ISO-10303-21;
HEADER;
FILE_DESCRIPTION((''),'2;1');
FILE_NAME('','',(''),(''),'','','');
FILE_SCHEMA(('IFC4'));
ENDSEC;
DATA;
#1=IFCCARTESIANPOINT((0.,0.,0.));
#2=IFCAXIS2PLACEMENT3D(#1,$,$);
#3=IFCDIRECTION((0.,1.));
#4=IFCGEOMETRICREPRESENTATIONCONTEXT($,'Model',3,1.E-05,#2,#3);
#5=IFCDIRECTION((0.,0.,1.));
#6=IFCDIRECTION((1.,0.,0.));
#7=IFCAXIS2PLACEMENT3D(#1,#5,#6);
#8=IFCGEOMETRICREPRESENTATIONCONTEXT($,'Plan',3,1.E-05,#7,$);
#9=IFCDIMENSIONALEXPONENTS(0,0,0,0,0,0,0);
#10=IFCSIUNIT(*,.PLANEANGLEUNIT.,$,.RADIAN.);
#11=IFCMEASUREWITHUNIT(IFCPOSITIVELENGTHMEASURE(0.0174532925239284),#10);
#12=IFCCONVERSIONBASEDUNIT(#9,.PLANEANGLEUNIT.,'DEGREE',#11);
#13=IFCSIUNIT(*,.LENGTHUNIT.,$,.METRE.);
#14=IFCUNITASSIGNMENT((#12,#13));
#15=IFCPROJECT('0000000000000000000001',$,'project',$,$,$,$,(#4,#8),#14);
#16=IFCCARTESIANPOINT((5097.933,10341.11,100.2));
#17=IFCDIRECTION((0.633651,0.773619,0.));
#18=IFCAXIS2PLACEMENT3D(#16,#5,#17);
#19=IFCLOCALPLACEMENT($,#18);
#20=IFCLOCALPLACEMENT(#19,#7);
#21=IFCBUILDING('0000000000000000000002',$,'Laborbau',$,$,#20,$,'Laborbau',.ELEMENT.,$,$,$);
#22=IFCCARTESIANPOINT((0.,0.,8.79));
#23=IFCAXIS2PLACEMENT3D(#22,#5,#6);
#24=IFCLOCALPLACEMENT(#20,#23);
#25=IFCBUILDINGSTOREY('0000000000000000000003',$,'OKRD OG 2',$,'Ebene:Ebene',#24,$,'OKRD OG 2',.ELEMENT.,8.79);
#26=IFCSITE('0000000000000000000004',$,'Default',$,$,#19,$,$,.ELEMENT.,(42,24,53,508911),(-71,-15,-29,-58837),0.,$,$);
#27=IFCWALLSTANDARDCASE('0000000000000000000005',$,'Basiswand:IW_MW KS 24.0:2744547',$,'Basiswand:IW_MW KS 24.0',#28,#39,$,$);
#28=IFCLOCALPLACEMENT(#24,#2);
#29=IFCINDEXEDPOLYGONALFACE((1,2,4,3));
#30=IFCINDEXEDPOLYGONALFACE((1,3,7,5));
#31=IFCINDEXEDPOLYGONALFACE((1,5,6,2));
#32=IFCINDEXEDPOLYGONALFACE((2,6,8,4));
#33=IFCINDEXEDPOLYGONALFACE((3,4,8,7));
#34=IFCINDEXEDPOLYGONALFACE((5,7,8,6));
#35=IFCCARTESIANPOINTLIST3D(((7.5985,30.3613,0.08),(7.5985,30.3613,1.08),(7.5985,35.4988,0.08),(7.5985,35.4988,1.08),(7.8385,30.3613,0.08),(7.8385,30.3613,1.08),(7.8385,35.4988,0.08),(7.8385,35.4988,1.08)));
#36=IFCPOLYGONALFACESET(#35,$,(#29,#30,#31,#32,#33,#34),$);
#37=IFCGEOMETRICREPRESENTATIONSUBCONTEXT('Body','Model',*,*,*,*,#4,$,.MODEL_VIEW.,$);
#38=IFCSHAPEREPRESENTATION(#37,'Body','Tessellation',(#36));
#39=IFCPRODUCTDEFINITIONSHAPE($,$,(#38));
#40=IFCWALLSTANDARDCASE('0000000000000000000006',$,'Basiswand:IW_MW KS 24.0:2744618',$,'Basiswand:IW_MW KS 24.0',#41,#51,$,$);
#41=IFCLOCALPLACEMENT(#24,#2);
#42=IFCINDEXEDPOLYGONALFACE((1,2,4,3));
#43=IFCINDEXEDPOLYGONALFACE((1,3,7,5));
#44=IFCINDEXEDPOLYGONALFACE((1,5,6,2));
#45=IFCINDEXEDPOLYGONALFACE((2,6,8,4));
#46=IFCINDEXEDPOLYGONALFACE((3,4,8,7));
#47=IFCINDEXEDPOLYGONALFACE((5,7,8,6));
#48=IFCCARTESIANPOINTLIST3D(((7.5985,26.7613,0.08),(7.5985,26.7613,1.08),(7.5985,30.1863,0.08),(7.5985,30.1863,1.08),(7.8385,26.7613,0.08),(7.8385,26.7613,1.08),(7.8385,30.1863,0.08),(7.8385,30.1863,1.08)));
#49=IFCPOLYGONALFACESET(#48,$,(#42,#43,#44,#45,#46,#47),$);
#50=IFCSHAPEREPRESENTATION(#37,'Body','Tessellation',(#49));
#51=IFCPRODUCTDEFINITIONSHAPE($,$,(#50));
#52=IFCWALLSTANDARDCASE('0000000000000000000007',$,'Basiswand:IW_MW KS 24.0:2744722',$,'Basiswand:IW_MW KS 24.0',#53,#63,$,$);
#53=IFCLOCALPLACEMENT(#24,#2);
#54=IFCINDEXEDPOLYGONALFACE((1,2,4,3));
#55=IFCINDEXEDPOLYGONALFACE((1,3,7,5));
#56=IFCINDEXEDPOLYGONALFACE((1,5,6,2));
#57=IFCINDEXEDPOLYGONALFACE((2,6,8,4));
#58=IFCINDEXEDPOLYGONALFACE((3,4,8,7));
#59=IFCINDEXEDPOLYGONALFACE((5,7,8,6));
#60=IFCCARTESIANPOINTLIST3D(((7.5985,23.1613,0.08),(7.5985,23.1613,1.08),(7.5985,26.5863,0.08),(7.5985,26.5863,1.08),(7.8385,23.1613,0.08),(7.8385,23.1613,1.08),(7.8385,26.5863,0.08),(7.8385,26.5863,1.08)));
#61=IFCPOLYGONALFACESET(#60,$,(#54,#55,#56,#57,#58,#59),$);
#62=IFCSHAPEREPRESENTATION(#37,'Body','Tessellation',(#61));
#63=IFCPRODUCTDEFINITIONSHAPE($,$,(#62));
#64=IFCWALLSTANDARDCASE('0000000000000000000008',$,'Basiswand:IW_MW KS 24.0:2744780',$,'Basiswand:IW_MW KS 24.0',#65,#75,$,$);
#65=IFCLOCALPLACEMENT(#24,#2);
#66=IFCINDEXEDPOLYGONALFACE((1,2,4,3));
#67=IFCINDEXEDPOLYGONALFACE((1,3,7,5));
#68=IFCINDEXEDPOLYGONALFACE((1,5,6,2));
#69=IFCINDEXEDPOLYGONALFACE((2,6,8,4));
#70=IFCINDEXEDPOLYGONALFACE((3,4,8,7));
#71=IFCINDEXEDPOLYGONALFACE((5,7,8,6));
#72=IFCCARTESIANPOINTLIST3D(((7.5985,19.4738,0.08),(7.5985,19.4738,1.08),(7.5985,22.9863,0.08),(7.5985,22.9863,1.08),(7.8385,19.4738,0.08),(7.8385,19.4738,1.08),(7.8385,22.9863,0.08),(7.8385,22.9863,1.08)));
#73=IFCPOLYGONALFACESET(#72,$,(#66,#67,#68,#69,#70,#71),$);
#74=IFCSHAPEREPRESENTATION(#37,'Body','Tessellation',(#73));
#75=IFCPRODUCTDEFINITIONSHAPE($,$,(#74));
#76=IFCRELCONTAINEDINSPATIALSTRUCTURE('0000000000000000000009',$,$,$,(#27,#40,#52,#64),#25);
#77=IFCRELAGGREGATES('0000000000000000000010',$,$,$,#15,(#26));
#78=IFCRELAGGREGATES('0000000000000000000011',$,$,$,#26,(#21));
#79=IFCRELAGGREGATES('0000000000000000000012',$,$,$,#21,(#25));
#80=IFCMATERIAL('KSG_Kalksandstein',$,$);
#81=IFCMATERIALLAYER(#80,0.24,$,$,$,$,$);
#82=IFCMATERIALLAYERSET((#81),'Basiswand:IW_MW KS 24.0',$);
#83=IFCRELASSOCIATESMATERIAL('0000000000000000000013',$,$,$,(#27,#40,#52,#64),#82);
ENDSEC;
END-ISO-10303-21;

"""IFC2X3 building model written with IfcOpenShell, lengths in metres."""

from ifc_helpers import new_model, entity, si_unit, converted_unit, direction, frame, frame_2d, origin, origin_with_axes, place, context, subcontext, project, spatial, rectangle, extrude, material, layer, layer_set, layer_usage, element, save


model = new_model("IFC2X3")

# Units and contexts
model_context = context("Model", 3, precision=1e-05, world=origin(), true_north=direction((0.0, 1.0)))
plan_context = context("Plan", 3, precision=1e-05, world=origin_with_axes())
body_context = subcontext(model_context, "Body", "Model", "MODEL_VIEW")
ifc_project = project(units=[converted_unit("PLANEANGLEUNIT", "DEGREE", entity("IfcPositiveLengthMeasure", 0.0174532925239284), si_unit("PLANEANGLEUNIT", "RADIAN"), dimensions=[0, 0, 0, 0, 0, 0, 0]), si_unit("LENGTHUNIT", "METRE")], contexts=[model_context, plan_context])

# Site, building, storey
site_placement = place(None, frame((5097.933, 10341.11, 100.2), z_axis=(0.0, 0.0, 1.0), x_axis=(0.633651, 0.773619, 0.0)))
site = spatial("IfcSite", under=ifc_project, at=site_placement, Name="Default", CompositionType="ELEMENT", RefLatitude=(42, 24, 53, 508911), RefLongitude=(-71, -15, -29, -58837), RefElevation=0.0)
building_placement = place(site_placement, origin_with_axes())
building = spatial("IfcBuilding", under=site, at=building_placement, Name="Laborbau", LongName="Laborbau", CompositionType="ELEMENT")
storey_placement = place(building_placement, frame((0.0, 0.0, 8.79), z_axis=(0.0, 0.0, 1.0), x_axis=(1.0, 0.0, 0.0)))
storey = spatial("IfcBuildingStorey", under=building, at=storey_placement, Name="OKRD OG 2", ObjectType="Ebene:Ebene", LongName="OKRD OG 2", CompositionType="ELEMENT", Elevation=8.79)

# Shared definitions
ifc_material_1 = material(Name="KSG_Kalksandstein")

# Walls
ifc_layer_1 = layer(ifc_material_1, 0.24)
ifc_layer_set_1 = layer_set([ifc_layer_1], Name="Basiswand:IW_MW KS 24.0")
ifc_layer_usage_1 = layer_usage(ifc_layer_set_1, "AXIS2", "NEGATIVE", 0.12)
wall_1_placement = place(storey_placement, frame((7.7185, 35.4988, 0.08), z_axis=(0.0, 0.0, 1.0), x_axis=(0.0, -1.0, 0.0)))
element("IfcWallStandardCase", 1, at=wall_1_placement, inside=storey, material=ifc_layer_usage_1, Name="Basiswand:IW_MW KS 24.0:2744547", ObjectType="Basiswand:IW_MW KS 24.0", context=body_context, shape_type="SweptSolid", body=[
    extrude(rectangle(XDim=5.1375, YDim=0.24, at=frame_2d((2.5688, 0.0), x_axis=(-1.0, 0.0))), origin(), (0.0, 0.0, 1.0), 1.0),
])
ifc_layer_usage_2 = layer_usage(ifc_layer_set_1, "AXIS2", "NEGATIVE", 0.12)
wall_2_placement = place(storey_placement, frame((7.7185, 30.1863, 0.08), z_axis=(0.0, 0.0, 1.0), x_axis=(0.0, -1.0, 0.0)))
element("IfcWallStandardCase", 2, at=wall_2_placement, inside=storey, material=ifc_layer_usage_2, Name="Basiswand:IW_MW KS 24.0:2744618", ObjectType="Basiswand:IW_MW KS 24.0", context=body_context, shape_type="SweptSolid", body=[
    extrude(rectangle(XDim=3.425, YDim=0.24, at=frame_2d((1.7125, 0.0), x_axis=(-1.0, 0.0))), origin(), (0.0, 0.0, 1.0), 1.0),
])
ifc_layer_usage_3 = layer_usage(ifc_layer_set_1, "AXIS2", "NEGATIVE", 0.12)
wall_3_placement = place(storey_placement, frame((7.7185, 26.5863, 0.08), z_axis=(0.0, 0.0, 1.0), x_axis=(0.0, -1.0, 0.0)))
element("IfcWallStandardCase", 3, at=wall_3_placement, inside=storey, material=ifc_layer_usage_3, Name="Basiswand:IW_MW KS 24.0:2744722", ObjectType="Basiswand:IW_MW KS 24.0", context=body_context, shape_type="SweptSolid", body=[
    extrude(rectangle(XDim=3.425, YDim=0.24, at=frame_2d((1.7125, 0.0), x_axis=(-1.0, 0.0))), origin(), (0.0, 0.0, 1.0), 1.0),
])
ifc_layer_usage_4 = layer_usage(ifc_layer_set_1, "AXIS2", "NEGATIVE", 0.12)
wall_4_placement = place(storey_placement, frame((7.7185, 22.9863, 0.08), z_axis=(0.0, 0.0, 1.0), x_axis=(0.0, -1.0, 0.0)))
element("IfcWallStandardCase", 4, at=wall_4_placement, inside=storey, material=ifc_layer_usage_4, Name="Basiswand:IW_MW KS 24.0:2744780", ObjectType="Basiswand:IW_MW KS 24.0", context=body_context, shape_type="SweptSolid", body=[
    extrude(rectangle(XDim=3.5125, YDim=0.24, at=frame_2d((1.7562, 0.0), x_axis=(-1.0, 0.0))), origin(), (0.0, 0.0, 1.0), 1.0),
])

save(model, "model.ifc")
